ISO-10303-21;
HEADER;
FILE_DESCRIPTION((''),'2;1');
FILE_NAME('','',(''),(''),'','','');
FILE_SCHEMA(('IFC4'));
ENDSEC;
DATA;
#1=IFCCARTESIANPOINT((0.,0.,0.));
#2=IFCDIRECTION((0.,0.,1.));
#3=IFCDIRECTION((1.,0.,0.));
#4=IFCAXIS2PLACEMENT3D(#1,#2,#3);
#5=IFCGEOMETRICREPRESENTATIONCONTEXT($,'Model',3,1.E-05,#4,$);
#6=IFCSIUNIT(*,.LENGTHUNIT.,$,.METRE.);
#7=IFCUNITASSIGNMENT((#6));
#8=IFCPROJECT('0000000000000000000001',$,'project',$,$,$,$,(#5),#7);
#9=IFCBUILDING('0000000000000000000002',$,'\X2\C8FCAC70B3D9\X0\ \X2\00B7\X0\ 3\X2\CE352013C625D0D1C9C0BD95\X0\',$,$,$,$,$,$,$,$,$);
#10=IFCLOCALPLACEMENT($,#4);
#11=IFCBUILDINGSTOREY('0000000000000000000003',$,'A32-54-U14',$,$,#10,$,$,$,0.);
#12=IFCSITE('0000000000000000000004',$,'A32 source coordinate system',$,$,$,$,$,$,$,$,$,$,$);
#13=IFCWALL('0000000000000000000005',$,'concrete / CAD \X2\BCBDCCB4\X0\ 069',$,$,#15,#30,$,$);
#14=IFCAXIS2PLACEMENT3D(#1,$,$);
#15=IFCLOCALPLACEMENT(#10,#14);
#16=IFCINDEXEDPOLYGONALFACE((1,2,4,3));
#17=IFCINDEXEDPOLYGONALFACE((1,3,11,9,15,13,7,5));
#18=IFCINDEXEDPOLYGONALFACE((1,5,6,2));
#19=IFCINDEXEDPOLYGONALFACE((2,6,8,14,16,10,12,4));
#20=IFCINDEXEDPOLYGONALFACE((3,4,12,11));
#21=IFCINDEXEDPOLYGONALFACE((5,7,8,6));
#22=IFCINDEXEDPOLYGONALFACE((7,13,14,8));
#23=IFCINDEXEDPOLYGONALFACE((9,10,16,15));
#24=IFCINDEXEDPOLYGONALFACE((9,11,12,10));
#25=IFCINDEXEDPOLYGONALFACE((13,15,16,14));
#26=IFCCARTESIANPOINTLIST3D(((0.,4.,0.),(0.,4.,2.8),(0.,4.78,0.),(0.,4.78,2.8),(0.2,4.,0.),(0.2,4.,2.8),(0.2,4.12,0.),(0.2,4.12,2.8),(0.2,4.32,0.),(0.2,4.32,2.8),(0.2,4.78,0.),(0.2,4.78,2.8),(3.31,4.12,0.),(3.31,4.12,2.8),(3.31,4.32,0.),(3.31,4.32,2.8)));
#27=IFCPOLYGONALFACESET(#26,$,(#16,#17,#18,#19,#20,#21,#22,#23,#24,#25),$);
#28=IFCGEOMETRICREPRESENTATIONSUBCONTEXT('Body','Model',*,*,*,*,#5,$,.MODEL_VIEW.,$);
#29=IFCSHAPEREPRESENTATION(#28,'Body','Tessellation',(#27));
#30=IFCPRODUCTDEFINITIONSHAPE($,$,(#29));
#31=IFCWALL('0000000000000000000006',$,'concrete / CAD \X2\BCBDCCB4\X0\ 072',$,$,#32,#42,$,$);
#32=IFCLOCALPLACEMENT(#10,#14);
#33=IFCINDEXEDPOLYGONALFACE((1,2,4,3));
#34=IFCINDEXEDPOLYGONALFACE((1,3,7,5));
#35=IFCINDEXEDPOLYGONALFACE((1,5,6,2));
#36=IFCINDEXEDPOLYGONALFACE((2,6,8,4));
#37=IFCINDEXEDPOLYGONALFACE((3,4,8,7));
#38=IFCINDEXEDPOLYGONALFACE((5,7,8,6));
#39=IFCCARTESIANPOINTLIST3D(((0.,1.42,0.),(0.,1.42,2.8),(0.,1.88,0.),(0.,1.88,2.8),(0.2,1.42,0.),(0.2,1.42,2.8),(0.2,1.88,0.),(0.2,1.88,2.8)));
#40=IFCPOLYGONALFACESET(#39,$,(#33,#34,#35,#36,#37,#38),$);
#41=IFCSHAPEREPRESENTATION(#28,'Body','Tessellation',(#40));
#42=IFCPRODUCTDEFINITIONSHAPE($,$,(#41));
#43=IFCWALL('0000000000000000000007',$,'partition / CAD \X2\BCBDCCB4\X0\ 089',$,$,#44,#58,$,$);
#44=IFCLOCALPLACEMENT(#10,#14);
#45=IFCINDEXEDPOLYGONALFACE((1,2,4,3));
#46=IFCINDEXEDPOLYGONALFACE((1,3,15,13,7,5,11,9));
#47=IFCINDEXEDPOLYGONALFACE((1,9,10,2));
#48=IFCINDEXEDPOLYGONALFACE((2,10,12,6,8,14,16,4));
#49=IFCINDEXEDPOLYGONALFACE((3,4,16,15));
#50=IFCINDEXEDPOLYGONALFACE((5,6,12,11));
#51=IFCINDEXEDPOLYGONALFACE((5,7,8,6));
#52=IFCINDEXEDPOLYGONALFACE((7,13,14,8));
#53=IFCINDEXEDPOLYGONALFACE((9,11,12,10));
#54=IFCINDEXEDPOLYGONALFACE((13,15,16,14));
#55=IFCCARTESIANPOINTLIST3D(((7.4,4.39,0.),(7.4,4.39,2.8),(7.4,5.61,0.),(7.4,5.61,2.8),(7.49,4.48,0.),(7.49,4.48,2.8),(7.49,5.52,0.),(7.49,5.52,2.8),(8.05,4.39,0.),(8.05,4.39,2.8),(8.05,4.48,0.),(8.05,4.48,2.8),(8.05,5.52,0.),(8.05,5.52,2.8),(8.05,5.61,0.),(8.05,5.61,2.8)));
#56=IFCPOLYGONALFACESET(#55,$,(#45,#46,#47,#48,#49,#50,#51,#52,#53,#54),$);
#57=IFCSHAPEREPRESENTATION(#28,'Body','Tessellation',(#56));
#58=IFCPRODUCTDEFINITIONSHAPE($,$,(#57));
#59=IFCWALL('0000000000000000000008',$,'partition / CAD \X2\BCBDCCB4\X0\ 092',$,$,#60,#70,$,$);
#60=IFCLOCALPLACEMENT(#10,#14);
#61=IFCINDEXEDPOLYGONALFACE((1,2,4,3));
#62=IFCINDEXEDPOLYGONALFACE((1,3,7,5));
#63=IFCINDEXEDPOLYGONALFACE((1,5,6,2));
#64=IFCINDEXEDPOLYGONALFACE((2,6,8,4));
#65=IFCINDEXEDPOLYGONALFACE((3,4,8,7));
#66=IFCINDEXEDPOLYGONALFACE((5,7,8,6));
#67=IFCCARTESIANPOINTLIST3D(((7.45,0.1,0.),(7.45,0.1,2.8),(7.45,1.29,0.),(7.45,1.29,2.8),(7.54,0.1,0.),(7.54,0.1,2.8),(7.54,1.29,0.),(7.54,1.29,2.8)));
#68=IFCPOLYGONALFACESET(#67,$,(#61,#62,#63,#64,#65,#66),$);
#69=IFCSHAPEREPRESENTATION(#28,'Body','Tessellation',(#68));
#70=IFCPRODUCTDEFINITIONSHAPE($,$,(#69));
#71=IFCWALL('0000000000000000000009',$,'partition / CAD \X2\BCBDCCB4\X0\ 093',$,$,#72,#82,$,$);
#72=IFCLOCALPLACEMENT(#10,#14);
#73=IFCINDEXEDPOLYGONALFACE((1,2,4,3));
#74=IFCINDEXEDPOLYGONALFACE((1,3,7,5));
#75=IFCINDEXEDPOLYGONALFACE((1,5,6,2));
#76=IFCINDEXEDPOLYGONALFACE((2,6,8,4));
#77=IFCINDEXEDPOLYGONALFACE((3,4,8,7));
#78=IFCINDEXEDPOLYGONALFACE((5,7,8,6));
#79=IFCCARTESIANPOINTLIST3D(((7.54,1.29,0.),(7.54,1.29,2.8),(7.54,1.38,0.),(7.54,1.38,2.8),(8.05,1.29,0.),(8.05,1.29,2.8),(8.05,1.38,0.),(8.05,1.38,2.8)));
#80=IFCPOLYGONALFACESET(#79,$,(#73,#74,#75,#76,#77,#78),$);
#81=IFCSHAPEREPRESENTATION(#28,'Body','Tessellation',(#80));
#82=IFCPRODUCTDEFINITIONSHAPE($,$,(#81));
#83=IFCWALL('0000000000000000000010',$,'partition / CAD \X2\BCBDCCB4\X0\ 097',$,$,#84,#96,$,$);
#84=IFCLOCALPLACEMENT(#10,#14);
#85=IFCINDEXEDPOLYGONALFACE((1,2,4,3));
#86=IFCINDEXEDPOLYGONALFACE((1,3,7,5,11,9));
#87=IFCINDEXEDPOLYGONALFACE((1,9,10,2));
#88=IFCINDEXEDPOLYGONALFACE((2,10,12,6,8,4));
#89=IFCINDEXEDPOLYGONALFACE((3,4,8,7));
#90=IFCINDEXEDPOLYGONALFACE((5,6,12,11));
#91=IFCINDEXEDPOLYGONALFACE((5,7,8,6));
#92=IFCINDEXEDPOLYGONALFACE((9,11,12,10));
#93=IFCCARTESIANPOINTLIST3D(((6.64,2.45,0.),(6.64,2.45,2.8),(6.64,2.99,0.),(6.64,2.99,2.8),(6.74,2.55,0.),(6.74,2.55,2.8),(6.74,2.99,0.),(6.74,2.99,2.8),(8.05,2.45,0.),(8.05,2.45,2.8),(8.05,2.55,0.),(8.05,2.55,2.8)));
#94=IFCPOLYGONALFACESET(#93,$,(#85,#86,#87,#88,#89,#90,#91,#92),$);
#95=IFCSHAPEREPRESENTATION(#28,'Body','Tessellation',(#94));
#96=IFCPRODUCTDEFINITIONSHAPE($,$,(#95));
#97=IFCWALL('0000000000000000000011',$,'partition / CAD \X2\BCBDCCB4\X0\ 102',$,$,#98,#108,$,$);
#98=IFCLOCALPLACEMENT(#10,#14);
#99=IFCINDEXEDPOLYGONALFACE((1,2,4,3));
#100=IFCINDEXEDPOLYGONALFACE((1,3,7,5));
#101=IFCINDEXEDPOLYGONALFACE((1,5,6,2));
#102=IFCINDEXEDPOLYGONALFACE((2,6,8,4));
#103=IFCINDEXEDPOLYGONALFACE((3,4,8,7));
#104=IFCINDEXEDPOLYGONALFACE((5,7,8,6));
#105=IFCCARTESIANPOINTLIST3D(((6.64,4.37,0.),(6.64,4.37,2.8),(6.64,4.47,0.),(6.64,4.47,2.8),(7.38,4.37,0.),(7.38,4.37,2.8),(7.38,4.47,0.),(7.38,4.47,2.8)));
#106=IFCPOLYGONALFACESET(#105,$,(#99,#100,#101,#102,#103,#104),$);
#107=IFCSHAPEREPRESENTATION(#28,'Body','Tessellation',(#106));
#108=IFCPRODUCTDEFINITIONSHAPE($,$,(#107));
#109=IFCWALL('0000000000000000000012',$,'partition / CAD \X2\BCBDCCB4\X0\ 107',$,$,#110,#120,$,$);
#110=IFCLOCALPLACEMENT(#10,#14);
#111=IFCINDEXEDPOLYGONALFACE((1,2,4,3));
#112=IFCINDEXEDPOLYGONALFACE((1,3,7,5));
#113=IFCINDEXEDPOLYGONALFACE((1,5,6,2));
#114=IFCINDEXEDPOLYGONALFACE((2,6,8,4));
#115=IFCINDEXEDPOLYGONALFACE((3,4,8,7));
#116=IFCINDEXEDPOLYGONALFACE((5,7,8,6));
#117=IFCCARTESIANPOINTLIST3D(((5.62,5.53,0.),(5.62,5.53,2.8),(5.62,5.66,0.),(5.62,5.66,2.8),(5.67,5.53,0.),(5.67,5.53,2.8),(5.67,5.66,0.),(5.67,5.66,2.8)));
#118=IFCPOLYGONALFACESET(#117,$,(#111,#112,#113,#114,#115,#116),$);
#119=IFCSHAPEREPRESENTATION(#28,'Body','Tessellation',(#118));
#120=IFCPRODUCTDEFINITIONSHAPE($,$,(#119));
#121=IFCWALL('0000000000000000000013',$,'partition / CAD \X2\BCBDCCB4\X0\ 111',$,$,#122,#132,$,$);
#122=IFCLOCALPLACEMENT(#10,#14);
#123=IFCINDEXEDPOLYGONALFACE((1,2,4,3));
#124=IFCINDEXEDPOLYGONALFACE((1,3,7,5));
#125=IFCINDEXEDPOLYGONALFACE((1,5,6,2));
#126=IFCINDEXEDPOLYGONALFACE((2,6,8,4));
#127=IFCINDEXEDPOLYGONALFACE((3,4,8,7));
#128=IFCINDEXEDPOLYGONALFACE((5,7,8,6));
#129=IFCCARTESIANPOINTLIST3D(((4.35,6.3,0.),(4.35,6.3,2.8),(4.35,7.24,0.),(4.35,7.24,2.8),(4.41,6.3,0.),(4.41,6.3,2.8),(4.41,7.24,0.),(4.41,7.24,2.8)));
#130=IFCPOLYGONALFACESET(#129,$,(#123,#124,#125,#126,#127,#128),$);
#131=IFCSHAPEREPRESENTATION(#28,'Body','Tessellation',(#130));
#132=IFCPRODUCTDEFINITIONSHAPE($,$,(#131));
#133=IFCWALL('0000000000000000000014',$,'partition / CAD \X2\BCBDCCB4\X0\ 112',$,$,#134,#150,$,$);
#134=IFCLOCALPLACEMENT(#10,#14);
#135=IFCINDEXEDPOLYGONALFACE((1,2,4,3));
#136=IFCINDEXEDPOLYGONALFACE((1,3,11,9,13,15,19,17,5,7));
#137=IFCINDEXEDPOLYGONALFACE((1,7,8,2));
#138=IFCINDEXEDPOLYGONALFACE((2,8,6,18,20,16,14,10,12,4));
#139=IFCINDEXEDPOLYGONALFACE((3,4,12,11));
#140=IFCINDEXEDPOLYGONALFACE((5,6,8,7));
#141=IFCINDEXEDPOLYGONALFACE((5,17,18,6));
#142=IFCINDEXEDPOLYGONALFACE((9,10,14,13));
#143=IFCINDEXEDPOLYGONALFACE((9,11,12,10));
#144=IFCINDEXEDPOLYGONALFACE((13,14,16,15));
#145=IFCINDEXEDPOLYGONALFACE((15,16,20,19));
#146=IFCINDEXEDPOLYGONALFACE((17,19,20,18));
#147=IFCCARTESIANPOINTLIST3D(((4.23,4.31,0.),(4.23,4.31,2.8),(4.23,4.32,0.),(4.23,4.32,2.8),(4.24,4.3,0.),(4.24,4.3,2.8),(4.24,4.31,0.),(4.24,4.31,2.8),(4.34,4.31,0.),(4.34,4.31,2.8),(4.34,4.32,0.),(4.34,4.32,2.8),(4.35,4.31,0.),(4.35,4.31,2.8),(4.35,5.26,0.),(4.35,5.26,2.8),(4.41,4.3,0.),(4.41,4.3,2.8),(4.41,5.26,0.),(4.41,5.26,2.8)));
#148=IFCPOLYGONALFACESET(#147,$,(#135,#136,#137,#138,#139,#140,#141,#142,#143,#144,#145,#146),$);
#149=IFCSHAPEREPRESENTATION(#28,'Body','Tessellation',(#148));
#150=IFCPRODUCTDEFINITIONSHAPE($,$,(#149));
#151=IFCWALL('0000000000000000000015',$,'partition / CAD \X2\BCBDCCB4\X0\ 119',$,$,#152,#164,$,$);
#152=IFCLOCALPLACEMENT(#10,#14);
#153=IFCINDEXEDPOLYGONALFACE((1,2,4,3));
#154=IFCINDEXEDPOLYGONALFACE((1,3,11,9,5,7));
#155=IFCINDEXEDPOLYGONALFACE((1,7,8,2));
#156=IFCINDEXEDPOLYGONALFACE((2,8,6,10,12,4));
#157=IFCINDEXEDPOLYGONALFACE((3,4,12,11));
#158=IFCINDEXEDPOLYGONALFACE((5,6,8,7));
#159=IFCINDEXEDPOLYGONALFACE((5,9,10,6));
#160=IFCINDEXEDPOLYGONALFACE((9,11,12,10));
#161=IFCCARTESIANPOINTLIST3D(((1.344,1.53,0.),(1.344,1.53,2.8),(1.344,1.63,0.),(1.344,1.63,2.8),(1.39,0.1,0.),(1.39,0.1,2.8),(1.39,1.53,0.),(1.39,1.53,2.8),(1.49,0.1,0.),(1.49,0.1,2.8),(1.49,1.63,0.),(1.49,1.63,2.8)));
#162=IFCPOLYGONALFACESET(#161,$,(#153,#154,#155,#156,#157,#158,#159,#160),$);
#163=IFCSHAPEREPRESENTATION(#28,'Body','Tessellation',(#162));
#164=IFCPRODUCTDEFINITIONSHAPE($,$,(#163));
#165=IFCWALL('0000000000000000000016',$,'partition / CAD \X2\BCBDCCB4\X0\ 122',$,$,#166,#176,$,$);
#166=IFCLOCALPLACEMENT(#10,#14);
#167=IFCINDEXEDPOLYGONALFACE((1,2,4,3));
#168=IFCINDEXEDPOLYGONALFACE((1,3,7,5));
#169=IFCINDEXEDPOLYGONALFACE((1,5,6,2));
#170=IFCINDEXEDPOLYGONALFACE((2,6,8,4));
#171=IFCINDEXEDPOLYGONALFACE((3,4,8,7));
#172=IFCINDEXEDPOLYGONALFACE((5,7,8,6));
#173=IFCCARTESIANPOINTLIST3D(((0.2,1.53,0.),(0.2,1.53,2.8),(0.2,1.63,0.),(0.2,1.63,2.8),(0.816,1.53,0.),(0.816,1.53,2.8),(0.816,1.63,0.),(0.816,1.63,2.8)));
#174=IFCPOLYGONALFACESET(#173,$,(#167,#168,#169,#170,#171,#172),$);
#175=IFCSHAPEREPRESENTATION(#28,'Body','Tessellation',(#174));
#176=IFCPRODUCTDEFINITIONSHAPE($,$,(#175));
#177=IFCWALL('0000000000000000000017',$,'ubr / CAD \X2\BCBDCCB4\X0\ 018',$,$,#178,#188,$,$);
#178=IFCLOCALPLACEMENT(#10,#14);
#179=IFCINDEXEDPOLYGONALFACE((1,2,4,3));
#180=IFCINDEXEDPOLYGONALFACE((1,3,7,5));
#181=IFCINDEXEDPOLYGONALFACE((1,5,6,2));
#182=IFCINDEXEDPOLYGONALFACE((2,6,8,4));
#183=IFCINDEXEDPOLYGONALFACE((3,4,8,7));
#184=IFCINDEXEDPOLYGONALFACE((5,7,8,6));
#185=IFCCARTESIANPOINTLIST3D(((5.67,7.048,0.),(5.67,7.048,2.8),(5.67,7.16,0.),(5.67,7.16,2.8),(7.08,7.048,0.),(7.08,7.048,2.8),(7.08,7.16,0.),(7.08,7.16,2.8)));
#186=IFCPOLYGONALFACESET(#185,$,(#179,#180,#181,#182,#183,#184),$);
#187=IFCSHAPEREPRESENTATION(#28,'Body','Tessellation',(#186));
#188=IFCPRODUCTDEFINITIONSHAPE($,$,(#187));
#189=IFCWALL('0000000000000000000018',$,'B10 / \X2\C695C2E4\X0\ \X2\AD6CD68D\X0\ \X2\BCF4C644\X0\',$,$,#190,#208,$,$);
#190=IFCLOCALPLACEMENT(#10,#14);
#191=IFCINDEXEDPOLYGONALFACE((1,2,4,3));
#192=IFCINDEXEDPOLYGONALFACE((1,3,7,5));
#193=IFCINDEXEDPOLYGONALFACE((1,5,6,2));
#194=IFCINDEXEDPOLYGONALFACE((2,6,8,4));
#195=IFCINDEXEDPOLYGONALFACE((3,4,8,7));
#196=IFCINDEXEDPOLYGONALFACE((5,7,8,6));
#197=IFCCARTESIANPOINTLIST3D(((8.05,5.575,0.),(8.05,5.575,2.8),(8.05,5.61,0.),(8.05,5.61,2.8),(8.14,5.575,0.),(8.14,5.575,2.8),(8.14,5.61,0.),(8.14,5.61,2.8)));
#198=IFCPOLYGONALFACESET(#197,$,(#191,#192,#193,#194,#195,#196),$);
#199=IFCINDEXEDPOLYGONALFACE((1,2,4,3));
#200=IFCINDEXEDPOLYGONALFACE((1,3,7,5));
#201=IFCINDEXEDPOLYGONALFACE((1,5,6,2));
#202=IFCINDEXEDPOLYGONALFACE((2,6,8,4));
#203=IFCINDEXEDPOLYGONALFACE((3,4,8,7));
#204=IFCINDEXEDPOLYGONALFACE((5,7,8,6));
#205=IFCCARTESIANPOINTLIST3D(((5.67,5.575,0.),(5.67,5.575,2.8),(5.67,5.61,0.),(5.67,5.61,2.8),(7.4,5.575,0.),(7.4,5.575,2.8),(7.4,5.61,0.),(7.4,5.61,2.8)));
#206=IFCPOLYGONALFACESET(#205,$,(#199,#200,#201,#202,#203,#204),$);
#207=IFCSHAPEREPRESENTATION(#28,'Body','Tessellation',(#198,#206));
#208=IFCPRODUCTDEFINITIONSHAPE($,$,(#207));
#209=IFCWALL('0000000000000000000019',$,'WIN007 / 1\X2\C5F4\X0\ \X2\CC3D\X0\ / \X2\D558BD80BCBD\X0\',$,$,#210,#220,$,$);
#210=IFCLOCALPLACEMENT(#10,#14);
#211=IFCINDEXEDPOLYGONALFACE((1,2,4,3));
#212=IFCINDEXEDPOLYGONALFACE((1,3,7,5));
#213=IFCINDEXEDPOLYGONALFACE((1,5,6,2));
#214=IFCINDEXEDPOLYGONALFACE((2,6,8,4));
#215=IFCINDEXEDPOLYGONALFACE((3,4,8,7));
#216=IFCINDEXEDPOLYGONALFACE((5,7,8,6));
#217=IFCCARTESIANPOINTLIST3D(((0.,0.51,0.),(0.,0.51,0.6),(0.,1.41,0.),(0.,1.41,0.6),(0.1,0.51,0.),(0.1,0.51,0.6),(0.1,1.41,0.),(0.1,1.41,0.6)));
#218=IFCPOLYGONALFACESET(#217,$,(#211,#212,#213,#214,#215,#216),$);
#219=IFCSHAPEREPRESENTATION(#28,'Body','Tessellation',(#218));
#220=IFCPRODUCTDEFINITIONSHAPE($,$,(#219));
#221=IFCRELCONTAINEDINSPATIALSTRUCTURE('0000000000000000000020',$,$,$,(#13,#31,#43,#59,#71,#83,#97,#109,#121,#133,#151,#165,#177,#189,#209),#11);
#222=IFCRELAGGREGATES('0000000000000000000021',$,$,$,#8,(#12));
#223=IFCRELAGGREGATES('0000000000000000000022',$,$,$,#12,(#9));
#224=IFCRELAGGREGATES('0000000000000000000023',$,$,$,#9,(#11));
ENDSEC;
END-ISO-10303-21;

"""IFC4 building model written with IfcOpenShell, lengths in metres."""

from ifc_helpers import new_model, si_unit, origin, origin_with_axes, place, context, subcontext, project, spatial, polyline, outline, extrude, element, save


model = new_model("IFC4")

# Units and contexts
model_context = context("Model", 3, precision=1e-05, world=origin_with_axes())
body_context = subcontext(model_context, "Body", "Model", "MODEL_VIEW")
ifc_project = project(units=[si_unit("LENGTHUNIT", "METRE")], contexts=[model_context])

# Site, building, storey
site = spatial("IfcSite", under=ifc_project, Name="A32 source coordinate system")
building = spatial("IfcBuilding", under=site, Name="주거동 · 3층–옥탑지붕")
storey_placement = place(None, origin_with_axes())
storey = spatial("IfcBuildingStorey", under=building, at=storey_placement, Name="A32-54-U14", Elevation=0.0)

# Walls
wall_1_placement = place(storey_placement, origin_with_axes())
element("IfcWall", 1, at=wall_1_placement, inside=storey, Name="concrete / CAD 벽체 069", context=body_context, shape_type="SweptSolid", body=[
    extrude(outline(polyline([(0.2, 4.12), (0.2, 4.0), (0.0, 4.0), (0.0, 4.78), (0.2, 4.78), (0.2, 4.32), (3.31, 4.32), (3.31, 4.12), (0.2, 4.12)])), origin(), (0.0, 0.0, 1.0), 2.8),
])
wall_2_placement = place(storey_placement, origin_with_axes())
element("IfcWall", 2, at=wall_2_placement, inside=storey, Name="concrete / CAD 벽체 072", context=body_context, shape_type="SweptSolid", body=[
    extrude(outline(polyline([(0.2, 1.88), (0.2, 1.42), (0.0, 1.42), (0.0, 1.88), (0.2, 1.88)])), origin(), (0.0, 0.0, 1.0), 2.8),
])
wall_3_placement = place(storey_placement, origin_with_axes())
element("IfcWall", 3, at=wall_3_placement, inside=storey, Name="partition / CAD 벽체 089", context=body_context, shape_type="SweptSolid", body=[
    extrude(outline(polyline([(7.49, 4.48), (8.05, 4.48), (8.05, 4.39), (7.4, 4.39), (7.4, 5.61), (8.05, 5.61), (8.05, 5.52), (7.49, 5.52), (7.49, 4.48)])), origin(), (0.0, 0.0, 1.0), 2.8),
])
wall_4_placement = place(storey_placement, origin_with_axes())
element("IfcWall", 4, at=wall_4_placement, inside=storey, Name="partition / CAD 벽체 092", context=body_context, shape_type="SweptSolid", body=[
    extrude(outline(polyline([(7.54, 1.29), (7.54, 0.1), (7.45, 0.1), (7.45, 1.29), (7.54, 1.29)])), origin(), (0.0, 0.0, 1.0), 2.8),
])
wall_5_placement = place(storey_placement, origin_with_axes())
element("IfcWall", 5, at=wall_5_placement, inside=storey, Name="partition / CAD 벽체 093", context=body_context, shape_type="SweptSolid", body=[
    extrude(outline(polyline([(8.05, 1.29), (7.54, 1.29), (7.54, 1.38), (8.05, 1.38), (8.05, 1.29)])), origin(), (0.0, 0.0, 1.0), 2.8),
])
wall_6_placement = place(storey_placement, origin_with_axes())
element("IfcWall", 6, at=wall_6_placement, inside=storey, Name="partition / CAD 벽체 097", context=body_context, shape_type="SweptSolid", body=[
    extrude(outline(polyline([(8.05, 2.45), (6.64, 2.45), (6.64, 2.99), (6.74, 2.99), (6.74, 2.55), (8.05, 2.55), (8.05, 2.45)])), origin(), (0.0, 0.0, 1.0), 2.8),
])
wall_7_placement = place(storey_placement, origin_with_axes())
element("IfcWall", 7, at=wall_7_placement, inside=storey, Name="partition / CAD 벽체 102", context=body_context, shape_type="SweptSolid", body=[
    extrude(outline(polyline([(7.38, 4.47), (7.38, 4.37), (6.64, 4.37), (6.64, 4.47), (7.38, 4.47)])), origin(), (0.0, 0.0, 1.0), 2.8),
])
wall_8_placement = place(storey_placement, origin_with_axes())
element("IfcWall", 8, at=wall_8_placement, inside=storey, Name="partition / CAD 벽체 107", context=body_context, shape_type="SweptSolid", body=[
    extrude(outline(polyline([(5.62, 5.53), (5.62, 5.66), (5.67, 5.66), (5.67, 5.53), (5.62, 5.53)])), origin(), (0.0, 0.0, 1.0), 2.8),
])
wall_9_placement = place(storey_placement, origin_with_axes())
element("IfcWall", 9, at=wall_9_placement, inside=storey, Name="partition / CAD 벽체 111", context=body_context, shape_type="SweptSolid", body=[
    extrude(outline(polyline([(4.41, 7.24), (4.41, 6.3), (4.35, 6.3), (4.35, 7.24), (4.41, 7.24)])), origin(), (0.0, 0.0, 1.0), 2.8),
])
wall_10_placement = place(storey_placement, origin_with_axes())
element("IfcWall", 10, at=wall_10_placement, inside=storey, Name="partition / CAD 벽체 112", context=body_context, shape_type="SweptSolid", body=[
    extrude(outline(polyline([(4.24, 4.3), (4.24, 4.31), (4.23, 4.31), (4.23, 4.32), (4.34, 4.32), (4.34, 4.31), (4.35, 4.31), (4.35, 5.26), (4.41, 5.26), (4.41, 4.3), (4.24, 4.3)])), origin(), (0.0, 0.0, 1.0), 2.8),
])
wall_11_placement = place(storey_placement, origin_with_axes())
element("IfcWall", 11, at=wall_11_placement, inside=storey, Name="partition / CAD 벽체 119", context=body_context, shape_type="SweptSolid", body=[
    extrude(outline(polyline([(1.344, 1.53), (1.344, 1.63), (1.49, 1.63), (1.49, 0.1), (1.39, 0.1), (1.39, 1.53), (1.344, 1.53)])), origin(), (0.0, 0.0, 1.0), 2.8),
])
wall_12_placement = place(storey_placement, origin_with_axes())
element("IfcWall", 12, at=wall_12_placement, inside=storey, Name="partition / CAD 벽체 122", context=body_context, shape_type="SweptSolid", body=[
    extrude(outline(polyline([(0.816, 1.63), (0.816, 1.53), (0.2, 1.53), (0.2, 1.63), (0.816, 1.63)])), origin(), (0.0, 0.0, 1.0), 2.8),
])
wall_13_placement = place(storey_placement, origin_with_axes())
element("IfcWall", 13, at=wall_13_placement, inside=storey, Name="ubr / CAD 벽체 018", context=body_context, shape_type="SweptSolid", body=[
    extrude(outline(polyline([(5.67, 7.16), (7.08, 7.16), (7.08, 7.048), (5.67, 7.048), (5.67, 7.16)])), origin(), (0.0, 0.0, 1.0), 2.8),
])
wall_14_placement = place(storey_placement, origin_with_axes())
element("IfcWall", 14, at=wall_14_placement, inside=storey, Name="B10 / 욕실 구획 보완", context=body_context, shape_type="SweptSolid", body=[
    extrude(outline(polyline([(8.14, 5.575), (8.05, 5.575), (8.05, 5.61), (8.14, 5.61), (8.14, 5.575)])), origin(), (0.0, 0.0, 1.0), 2.8),
    extrude(outline(polyline([(7.4, 5.575), (5.67, 5.575), (5.67, 5.61), (7.4, 5.61), (7.4, 5.575)])), origin(), (0.0, 0.0, 1.0), 2.8),
])
wall_15_placement = place(storey_placement, origin_with_axes())
element("IfcWall", 15, at=wall_15_placement, inside=storey, Name="WIN007 / 1열 창 / 하부벽", context=body_context, shape_type="SweptSolid", body=[
    extrude(outline(polyline([(0.1, 1.41), (0.1, 0.51), (0.0, 0.51), (0.0, 1.41), (0.1, 1.41)])), origin(), (0.0, 0.0, 1.0), 0.6),
])

save(model, "model.ifc")
